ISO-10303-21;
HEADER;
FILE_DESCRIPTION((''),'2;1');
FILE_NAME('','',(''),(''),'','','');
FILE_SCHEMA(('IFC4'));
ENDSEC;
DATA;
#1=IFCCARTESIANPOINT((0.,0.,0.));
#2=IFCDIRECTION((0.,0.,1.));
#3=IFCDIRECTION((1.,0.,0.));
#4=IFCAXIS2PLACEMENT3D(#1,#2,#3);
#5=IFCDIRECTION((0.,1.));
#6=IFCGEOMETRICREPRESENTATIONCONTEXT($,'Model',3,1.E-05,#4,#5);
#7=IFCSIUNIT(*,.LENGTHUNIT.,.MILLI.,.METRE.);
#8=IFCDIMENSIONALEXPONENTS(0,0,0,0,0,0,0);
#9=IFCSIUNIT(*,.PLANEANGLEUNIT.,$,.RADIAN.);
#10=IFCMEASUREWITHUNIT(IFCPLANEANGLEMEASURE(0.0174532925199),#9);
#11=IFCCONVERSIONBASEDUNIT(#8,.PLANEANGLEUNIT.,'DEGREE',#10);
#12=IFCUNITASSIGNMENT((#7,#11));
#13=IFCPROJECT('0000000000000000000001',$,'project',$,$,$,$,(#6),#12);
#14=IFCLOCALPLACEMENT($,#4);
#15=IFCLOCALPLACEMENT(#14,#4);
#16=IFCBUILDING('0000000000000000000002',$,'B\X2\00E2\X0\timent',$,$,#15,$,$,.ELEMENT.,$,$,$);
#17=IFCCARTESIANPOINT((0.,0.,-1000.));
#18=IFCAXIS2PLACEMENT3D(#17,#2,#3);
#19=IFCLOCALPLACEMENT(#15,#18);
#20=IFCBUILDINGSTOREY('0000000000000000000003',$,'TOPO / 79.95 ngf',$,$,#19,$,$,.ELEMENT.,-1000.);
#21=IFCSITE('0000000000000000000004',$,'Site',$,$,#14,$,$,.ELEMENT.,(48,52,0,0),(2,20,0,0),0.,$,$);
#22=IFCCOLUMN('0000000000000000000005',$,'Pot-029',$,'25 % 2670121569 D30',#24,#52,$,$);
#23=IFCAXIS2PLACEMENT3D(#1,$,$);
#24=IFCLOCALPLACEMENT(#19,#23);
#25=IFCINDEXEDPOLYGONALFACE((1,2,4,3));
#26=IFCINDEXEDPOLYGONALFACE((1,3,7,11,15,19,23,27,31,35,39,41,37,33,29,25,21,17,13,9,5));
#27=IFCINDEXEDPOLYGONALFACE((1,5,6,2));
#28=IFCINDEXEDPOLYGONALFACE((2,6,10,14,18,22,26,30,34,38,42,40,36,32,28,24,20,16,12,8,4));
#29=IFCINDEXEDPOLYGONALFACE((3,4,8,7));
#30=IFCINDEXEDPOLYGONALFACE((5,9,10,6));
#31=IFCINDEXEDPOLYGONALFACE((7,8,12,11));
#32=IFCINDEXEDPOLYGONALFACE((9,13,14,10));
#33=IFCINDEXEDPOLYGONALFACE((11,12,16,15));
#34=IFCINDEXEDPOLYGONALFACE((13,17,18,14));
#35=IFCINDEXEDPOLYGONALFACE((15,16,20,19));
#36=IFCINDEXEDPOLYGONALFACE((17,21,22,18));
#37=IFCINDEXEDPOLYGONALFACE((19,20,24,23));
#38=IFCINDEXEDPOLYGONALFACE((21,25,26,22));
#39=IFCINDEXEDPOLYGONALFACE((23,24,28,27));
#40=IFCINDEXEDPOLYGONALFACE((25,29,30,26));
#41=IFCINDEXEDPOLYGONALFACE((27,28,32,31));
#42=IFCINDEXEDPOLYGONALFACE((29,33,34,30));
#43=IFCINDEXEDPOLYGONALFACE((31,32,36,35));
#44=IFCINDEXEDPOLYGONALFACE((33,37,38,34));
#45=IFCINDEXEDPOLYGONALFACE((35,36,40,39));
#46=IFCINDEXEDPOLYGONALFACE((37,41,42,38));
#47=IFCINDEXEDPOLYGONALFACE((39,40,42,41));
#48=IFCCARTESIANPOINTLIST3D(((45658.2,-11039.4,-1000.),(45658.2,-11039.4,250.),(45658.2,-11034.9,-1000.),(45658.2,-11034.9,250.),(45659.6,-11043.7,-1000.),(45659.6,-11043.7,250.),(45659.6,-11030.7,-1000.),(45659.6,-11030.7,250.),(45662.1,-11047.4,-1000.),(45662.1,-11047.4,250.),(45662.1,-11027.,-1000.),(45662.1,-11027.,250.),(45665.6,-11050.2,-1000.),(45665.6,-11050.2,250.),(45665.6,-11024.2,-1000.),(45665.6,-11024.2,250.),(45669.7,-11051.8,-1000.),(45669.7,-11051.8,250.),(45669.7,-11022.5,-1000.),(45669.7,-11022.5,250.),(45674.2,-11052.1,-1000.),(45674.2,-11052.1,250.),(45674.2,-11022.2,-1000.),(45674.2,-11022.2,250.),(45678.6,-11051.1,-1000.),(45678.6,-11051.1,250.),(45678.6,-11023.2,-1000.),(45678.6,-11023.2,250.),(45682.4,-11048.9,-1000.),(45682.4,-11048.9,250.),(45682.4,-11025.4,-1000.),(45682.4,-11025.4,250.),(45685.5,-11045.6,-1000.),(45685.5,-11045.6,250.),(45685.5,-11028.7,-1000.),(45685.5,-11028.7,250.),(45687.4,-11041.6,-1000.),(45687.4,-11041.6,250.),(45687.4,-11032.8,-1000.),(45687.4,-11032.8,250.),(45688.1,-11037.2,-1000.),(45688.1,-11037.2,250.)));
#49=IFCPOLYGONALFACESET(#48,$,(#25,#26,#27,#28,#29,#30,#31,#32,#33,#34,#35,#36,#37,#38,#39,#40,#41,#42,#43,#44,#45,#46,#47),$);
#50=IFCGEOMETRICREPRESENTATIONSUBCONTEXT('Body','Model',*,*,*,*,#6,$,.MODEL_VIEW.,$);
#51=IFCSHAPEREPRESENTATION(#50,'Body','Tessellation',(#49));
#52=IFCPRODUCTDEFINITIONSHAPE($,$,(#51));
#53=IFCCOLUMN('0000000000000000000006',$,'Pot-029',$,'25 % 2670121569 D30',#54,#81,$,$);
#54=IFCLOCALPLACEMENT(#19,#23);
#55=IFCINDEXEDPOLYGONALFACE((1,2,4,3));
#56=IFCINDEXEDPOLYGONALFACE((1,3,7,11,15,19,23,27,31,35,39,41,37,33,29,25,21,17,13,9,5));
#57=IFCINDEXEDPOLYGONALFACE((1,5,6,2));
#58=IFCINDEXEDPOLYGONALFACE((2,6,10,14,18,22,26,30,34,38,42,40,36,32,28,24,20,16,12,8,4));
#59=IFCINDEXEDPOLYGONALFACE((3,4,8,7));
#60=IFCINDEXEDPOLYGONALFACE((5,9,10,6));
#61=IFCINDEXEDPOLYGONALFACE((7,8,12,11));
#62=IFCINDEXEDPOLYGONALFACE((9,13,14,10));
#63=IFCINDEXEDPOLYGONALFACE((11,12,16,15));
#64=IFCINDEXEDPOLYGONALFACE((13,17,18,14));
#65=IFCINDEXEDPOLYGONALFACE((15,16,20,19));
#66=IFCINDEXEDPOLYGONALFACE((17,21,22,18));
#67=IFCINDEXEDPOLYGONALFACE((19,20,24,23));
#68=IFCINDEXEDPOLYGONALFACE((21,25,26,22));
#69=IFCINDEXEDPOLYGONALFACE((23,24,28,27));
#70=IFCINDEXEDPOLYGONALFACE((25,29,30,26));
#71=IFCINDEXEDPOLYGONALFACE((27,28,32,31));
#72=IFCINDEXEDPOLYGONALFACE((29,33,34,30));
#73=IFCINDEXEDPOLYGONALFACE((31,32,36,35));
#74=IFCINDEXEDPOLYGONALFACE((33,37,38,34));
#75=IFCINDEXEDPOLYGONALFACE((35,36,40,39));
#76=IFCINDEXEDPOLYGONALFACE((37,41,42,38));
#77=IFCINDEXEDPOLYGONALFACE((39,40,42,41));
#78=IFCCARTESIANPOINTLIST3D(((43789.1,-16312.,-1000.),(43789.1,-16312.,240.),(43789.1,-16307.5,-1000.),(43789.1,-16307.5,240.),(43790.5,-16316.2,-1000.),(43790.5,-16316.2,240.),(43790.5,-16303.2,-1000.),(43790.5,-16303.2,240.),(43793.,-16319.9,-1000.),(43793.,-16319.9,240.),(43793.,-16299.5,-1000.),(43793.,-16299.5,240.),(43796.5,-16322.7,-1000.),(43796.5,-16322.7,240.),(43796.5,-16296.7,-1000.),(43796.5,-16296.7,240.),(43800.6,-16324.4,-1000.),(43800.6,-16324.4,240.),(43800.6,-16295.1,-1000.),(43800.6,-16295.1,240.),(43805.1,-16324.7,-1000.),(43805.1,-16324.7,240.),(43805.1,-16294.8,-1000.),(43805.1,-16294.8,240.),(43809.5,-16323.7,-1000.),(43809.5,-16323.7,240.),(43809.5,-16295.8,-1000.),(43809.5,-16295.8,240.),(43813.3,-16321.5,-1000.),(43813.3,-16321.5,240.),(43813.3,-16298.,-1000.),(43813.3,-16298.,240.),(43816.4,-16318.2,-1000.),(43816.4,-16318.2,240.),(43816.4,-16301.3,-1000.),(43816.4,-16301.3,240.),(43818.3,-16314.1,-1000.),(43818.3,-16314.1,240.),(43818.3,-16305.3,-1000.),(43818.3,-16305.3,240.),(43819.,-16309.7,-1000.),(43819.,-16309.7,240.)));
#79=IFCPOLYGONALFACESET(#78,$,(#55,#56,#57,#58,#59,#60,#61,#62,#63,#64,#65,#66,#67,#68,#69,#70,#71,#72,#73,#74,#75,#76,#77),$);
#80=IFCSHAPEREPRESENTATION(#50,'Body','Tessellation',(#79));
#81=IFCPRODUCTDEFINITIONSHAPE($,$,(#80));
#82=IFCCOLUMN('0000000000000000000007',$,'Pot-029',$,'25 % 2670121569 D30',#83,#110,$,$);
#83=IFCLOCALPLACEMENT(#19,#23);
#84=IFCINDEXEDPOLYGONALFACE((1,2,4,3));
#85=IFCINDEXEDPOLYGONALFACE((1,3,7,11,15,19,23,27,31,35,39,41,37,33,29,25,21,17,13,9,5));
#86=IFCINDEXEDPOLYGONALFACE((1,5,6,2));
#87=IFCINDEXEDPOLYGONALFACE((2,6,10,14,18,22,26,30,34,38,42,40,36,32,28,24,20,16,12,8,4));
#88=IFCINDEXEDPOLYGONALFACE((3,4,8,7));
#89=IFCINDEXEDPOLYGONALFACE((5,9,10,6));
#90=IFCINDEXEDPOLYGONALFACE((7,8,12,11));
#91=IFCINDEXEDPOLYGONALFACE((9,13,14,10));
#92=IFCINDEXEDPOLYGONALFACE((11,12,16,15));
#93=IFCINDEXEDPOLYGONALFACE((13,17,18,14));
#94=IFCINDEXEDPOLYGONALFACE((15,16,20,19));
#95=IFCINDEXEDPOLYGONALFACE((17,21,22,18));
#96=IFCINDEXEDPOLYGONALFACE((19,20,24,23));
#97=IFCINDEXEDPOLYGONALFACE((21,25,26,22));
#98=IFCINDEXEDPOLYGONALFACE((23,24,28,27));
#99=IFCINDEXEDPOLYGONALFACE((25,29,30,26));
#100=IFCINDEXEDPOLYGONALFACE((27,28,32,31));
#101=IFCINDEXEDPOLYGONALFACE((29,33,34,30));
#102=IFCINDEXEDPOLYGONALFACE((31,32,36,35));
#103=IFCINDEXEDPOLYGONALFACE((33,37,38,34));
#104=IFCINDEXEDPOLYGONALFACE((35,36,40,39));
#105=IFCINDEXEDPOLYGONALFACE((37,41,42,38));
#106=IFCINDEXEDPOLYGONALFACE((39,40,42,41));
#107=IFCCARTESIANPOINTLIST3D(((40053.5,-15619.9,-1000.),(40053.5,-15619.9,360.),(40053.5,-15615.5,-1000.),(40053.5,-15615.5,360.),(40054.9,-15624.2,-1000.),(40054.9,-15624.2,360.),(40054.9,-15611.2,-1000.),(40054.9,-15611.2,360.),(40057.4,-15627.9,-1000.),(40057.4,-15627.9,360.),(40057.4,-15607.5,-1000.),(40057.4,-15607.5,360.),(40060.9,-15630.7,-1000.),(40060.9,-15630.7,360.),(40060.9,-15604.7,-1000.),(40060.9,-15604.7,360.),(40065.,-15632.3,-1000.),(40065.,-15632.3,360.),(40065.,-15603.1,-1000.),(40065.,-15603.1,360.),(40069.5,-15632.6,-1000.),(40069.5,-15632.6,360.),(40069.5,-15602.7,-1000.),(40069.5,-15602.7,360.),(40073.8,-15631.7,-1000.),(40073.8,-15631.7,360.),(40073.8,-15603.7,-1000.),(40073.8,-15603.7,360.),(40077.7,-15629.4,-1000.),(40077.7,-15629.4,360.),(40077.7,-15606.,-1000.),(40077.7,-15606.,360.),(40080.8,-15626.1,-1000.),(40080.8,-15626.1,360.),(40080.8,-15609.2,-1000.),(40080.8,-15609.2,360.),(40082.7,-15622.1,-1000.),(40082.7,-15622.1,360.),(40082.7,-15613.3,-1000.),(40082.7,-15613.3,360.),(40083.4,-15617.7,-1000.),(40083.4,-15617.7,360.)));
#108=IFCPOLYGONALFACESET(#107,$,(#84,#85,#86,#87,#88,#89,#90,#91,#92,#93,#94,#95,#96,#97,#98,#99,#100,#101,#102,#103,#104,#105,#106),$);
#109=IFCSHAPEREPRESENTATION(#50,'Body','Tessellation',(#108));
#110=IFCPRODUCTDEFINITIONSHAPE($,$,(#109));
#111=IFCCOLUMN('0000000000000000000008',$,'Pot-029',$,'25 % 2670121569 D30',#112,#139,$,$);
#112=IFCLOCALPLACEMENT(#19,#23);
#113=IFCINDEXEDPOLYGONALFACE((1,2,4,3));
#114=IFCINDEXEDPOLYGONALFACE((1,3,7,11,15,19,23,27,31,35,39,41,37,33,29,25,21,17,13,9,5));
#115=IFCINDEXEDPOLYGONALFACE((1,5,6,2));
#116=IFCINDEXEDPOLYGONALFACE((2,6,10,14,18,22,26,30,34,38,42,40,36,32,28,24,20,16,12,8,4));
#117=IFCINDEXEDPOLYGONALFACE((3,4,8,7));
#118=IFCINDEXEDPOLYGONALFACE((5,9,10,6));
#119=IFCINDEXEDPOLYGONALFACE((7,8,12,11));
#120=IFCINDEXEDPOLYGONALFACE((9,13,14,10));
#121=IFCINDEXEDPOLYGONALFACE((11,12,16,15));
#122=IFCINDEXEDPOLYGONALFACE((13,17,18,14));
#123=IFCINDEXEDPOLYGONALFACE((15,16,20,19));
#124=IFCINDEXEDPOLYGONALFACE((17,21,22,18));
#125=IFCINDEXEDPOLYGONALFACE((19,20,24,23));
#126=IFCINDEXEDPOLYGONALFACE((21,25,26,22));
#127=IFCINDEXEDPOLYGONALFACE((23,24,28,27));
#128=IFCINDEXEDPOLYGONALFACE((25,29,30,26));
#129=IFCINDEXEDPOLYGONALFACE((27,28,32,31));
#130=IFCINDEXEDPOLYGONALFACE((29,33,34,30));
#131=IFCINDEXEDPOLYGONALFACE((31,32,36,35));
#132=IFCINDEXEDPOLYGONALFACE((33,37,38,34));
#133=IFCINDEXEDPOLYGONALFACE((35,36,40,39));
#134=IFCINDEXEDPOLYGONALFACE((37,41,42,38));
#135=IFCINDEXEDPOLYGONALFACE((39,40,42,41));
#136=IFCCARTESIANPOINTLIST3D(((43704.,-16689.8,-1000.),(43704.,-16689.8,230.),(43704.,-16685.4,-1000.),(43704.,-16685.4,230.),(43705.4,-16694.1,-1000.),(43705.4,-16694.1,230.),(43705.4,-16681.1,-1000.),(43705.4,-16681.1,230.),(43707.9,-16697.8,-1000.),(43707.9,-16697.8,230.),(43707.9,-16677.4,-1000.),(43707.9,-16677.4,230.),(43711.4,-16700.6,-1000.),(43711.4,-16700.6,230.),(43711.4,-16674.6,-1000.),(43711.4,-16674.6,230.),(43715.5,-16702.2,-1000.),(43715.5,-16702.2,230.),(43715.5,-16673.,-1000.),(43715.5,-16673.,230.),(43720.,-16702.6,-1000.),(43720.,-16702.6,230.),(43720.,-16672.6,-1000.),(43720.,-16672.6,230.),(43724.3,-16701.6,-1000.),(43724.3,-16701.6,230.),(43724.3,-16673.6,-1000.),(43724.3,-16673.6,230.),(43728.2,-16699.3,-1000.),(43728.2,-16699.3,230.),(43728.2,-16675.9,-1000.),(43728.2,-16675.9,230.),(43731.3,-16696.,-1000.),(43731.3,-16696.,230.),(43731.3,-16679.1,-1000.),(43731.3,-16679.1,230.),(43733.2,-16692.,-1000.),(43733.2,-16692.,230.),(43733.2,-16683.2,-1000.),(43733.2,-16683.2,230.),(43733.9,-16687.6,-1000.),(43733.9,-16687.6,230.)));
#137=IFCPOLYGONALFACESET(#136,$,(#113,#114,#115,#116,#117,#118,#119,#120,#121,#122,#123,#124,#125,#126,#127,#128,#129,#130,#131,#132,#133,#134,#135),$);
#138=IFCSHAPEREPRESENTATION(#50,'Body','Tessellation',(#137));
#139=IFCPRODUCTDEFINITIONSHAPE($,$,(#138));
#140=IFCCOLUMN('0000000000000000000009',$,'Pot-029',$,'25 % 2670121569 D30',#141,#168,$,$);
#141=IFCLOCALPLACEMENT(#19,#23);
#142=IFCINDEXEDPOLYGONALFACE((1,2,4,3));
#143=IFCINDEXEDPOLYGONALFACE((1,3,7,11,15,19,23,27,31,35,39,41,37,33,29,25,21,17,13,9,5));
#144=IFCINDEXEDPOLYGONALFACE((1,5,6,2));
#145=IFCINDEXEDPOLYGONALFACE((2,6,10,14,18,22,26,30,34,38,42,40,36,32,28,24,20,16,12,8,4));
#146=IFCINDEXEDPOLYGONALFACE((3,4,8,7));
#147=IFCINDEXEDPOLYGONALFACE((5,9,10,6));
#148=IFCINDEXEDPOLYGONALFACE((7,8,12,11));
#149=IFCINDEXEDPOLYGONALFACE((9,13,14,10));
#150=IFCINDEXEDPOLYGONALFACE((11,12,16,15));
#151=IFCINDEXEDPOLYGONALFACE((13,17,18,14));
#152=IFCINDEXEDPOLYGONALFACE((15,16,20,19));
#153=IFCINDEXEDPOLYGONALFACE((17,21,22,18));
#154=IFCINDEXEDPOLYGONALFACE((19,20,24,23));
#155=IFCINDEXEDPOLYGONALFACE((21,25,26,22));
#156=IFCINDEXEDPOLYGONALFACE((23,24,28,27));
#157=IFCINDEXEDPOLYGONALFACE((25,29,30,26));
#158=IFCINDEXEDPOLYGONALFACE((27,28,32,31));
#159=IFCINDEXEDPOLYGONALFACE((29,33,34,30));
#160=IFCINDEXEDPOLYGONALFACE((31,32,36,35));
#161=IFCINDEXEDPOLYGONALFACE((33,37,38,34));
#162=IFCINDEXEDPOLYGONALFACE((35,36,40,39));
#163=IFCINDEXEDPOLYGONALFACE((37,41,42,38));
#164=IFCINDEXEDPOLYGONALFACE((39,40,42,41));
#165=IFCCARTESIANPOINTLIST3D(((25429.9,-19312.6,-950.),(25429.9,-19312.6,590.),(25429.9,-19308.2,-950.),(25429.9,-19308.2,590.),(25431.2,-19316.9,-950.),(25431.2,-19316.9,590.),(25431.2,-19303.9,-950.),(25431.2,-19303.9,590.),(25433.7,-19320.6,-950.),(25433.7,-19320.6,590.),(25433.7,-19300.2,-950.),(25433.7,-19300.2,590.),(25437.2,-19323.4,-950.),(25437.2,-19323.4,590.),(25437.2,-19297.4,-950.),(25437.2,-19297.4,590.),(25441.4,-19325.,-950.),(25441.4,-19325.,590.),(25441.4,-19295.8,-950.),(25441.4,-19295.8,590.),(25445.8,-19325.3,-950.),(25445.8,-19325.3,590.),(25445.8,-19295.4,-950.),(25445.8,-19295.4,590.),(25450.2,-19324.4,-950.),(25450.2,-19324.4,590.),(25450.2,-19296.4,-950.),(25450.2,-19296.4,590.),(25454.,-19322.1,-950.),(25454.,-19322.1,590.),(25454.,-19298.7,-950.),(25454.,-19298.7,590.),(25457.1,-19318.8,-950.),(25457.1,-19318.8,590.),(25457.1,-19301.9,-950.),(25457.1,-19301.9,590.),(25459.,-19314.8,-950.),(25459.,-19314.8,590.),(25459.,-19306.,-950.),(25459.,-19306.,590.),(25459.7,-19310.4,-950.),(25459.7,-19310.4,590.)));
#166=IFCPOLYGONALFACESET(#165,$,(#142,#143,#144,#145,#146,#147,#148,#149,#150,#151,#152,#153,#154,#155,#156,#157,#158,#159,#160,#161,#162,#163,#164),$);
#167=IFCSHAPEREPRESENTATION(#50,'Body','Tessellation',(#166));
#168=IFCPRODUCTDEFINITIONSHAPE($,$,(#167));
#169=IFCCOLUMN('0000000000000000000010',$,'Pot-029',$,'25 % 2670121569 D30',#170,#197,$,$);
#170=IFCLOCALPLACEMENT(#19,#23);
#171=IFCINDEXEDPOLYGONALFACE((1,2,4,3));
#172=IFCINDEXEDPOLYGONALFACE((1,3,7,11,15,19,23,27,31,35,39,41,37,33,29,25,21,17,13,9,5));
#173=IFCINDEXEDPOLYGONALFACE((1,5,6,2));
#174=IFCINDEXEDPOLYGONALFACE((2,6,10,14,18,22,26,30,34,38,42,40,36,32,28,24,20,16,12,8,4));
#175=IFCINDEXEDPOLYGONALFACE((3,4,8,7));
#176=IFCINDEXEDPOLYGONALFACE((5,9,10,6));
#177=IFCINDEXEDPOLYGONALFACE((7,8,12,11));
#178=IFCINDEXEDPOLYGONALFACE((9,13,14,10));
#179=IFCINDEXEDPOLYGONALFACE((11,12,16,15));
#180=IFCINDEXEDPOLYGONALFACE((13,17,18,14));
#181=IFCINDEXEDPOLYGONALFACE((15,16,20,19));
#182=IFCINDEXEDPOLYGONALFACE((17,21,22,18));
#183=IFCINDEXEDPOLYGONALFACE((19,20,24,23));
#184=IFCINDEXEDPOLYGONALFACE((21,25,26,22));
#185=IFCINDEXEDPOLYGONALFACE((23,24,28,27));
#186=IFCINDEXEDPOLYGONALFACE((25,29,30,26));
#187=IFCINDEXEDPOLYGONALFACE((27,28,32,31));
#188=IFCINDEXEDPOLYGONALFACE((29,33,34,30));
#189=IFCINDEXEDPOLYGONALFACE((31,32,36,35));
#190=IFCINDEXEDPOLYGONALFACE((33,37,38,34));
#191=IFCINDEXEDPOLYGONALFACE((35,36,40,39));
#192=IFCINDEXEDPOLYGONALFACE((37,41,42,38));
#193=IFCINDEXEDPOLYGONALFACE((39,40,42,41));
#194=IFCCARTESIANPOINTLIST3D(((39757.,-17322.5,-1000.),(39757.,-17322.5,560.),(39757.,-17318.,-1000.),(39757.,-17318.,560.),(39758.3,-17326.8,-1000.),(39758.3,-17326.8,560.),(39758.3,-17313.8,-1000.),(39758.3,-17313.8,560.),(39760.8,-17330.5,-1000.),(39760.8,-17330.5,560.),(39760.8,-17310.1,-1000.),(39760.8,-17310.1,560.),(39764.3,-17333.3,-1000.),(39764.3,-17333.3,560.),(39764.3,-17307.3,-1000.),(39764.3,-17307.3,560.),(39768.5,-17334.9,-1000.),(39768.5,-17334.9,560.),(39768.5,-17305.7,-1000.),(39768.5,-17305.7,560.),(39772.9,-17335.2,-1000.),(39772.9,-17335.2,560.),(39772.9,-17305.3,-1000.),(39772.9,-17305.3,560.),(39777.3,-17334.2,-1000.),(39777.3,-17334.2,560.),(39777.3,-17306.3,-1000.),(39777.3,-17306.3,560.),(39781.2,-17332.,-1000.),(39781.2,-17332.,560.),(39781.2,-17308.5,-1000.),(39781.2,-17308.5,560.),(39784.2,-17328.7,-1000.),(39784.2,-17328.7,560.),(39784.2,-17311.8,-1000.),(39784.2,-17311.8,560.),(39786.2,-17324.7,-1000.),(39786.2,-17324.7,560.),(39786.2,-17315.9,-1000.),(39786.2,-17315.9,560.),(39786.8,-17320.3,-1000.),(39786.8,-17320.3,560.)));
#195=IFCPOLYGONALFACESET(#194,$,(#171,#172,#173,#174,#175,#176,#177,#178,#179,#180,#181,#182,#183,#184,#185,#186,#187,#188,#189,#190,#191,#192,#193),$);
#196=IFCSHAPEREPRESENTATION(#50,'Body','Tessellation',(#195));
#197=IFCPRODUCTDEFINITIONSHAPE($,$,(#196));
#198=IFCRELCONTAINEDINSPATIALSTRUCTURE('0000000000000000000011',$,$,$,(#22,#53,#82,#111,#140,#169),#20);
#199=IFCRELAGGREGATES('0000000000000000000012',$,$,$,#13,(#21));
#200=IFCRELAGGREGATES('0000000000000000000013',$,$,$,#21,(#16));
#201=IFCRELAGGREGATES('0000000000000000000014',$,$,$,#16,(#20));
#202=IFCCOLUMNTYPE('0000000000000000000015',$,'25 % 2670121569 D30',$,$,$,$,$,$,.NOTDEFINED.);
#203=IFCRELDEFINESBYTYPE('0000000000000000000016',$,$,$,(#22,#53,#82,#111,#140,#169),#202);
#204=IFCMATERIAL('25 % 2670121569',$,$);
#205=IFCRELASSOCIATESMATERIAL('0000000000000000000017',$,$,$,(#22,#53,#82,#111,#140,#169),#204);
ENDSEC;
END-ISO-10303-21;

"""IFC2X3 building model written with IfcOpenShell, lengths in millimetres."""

from ifc_helpers import new_model, entity, si_unit, converted_unit, direction, frame, origin_with_axes, origin_2d_with_axis, place, context, subcontext, project, spatial, circle, extrude, material, type_object, element, save


model = new_model("IFC2X3")

# Units and contexts
model_context = context("Model", 3, precision=1e-05, world=origin_with_axes(), true_north=direction((0.0, 1.0)))
body_context = subcontext(model_context, "Body", "Model", "MODEL_VIEW")
ifc_project = project(units=[si_unit("LENGTHUNIT", "METRE", prefix="MILLI"), converted_unit("PLANEANGLEUNIT", "DEGREE", entity("IfcPlaneAngleMeasure", 0.0174532925199), si_unit("PLANEANGLEUNIT", "RADIAN"), dimensions=[0, 0, 0, 0, 0, 0, 0])], contexts=[model_context])

# Site, building, storey
site_placement = place(None, origin_with_axes())
site = spatial("IfcSite", under=ifc_project, at=site_placement, Name="Site", CompositionType="ELEMENT", RefLatitude=(48, 52, 0, 0), RefLongitude=(2, 20, 0, 0), RefElevation=0.0)
building_placement = place(site_placement, origin_with_axes())
building = spatial("IfcBuilding", under=site, at=building_placement, Name="Bâtiment", CompositionType="ELEMENT")
storey_placement = place(building_placement, frame((0.0, 0.0, -1000.0), z_axis=(0.0, 0.0, 1.0), x_axis=(1.0, 0.0, 0.0)))
storey = spatial("IfcBuildingStorey", under=building, at=storey_placement, Name="TOPO / 79.95 ngf", CompositionType="ELEMENT", Elevation=-1000.0)

# Columns
ifc_material_1 = material(Name="25 % 2670121569")
column_type_1 = type_object("IfcColumnType", Name="25 % 2670121569 D30", PredefinedType="NOTDEFINED")
column_1_placement = place(storey_placement, frame((45673.1, -11037.2, -1000.0), z_axis=(0.0, 0.0, 1.0), x_axis=(1.0, 0.0, 0.0)))
element("IfcColumn", 1, at=column_1_placement, inside=storey, type_object=column_type_1, material=ifc_material_1, Name="Pot-029", ObjectType="25 % 2670121569 D30", context=body_context, shape_type="SweptSolid", body=[
    extrude(circle(Radius=15.0, at=origin_2d_with_axis()), origin_with_axes(), (0.0, 0.0, 1.0), 1250.0),
])
column_2_placement = place(storey_placement, frame((43804.0, -16309.7, -1000.0), z_axis=(0.0, 0.0, 1.0), x_axis=(1.0, 0.0, 0.0)))
element("IfcColumn", 2, at=column_2_placement, inside=storey, type_object=column_type_1, material=ifc_material_1, Name="Pot-029", ObjectType="25 % 2670121569 D30", context=body_context, shape_type="SweptSolid", body=[
    extrude(circle(Radius=15.0, at=origin_2d_with_axis()), origin_with_axes(), (0.0, 0.0, 1.0), 1240.0),
])
column_3_placement = place(storey_placement, frame((40068.4, -15617.7, -1000.0), z_axis=(0.0, 0.0, 1.0), x_axis=(1.0, 0.0, 0.0)))
element("IfcColumn", 3, at=column_3_placement, inside=storey, type_object=column_type_1, material=ifc_material_1, Name="Pot-029", ObjectType="25 % 2670121569 D30", context=body_context, shape_type="SweptSolid", body=[
    extrude(circle(Radius=15.0, at=origin_2d_with_axis()), origin_with_axes(), (0.0, 0.0, 1.0), 1360.0),
])
column_4_placement = place(storey_placement, frame((43718.9, -16687.6, -1000.0), z_axis=(0.0, 0.0, 1.0), x_axis=(1.0, 0.0, 0.0)))
element("IfcColumn", 4, at=column_4_placement, inside=storey, type_object=column_type_1, material=ifc_material_1, Name="Pot-029", ObjectType="25 % 2670121569 D30", context=body_context, shape_type="SweptSolid", body=[
    extrude(circle(Radius=15.0, at=origin_2d_with_axis()), origin_with_axes(), (0.0, 0.0, 1.0), 1230.0),
])
column_5_placement = place(storey_placement, frame((25444.7, -19310.4, -950.0), z_axis=(0.0, 0.0, 1.0), x_axis=(1.0, 0.0, 0.0)))
element("IfcColumn", 5, at=column_5_placement, inside=storey, type_object=column_type_1, material=ifc_material_1, Name="Pot-029", ObjectType="25 % 2670121569 D30", context=body_context, shape_type="SweptSolid", body=[
    extrude(circle(Radius=15.0, at=origin_2d_with_axis()), origin_with_axes(), (0.0, 0.0, 1.0), 1540.0),
])
column_6_placement = place(storey_placement, frame((39771.8, -17320.3, -1000.0), z_axis=(0.0, 0.0, 1.0), x_axis=(1.0, 0.0, 0.0)))
element("IfcColumn", 6, at=column_6_placement, inside=storey, type_object=column_type_1, material=ifc_material_1, Name="Pot-029", ObjectType="25 % 2670121569 D30", context=body_context, shape_type="SweptSolid", body=[
    extrude(circle(Radius=15.0, at=origin_2d_with_axis()), origin_with_axes(), (0.0, 0.0, 1.0), 1560.0),
])

save(model, "model.ifc")
